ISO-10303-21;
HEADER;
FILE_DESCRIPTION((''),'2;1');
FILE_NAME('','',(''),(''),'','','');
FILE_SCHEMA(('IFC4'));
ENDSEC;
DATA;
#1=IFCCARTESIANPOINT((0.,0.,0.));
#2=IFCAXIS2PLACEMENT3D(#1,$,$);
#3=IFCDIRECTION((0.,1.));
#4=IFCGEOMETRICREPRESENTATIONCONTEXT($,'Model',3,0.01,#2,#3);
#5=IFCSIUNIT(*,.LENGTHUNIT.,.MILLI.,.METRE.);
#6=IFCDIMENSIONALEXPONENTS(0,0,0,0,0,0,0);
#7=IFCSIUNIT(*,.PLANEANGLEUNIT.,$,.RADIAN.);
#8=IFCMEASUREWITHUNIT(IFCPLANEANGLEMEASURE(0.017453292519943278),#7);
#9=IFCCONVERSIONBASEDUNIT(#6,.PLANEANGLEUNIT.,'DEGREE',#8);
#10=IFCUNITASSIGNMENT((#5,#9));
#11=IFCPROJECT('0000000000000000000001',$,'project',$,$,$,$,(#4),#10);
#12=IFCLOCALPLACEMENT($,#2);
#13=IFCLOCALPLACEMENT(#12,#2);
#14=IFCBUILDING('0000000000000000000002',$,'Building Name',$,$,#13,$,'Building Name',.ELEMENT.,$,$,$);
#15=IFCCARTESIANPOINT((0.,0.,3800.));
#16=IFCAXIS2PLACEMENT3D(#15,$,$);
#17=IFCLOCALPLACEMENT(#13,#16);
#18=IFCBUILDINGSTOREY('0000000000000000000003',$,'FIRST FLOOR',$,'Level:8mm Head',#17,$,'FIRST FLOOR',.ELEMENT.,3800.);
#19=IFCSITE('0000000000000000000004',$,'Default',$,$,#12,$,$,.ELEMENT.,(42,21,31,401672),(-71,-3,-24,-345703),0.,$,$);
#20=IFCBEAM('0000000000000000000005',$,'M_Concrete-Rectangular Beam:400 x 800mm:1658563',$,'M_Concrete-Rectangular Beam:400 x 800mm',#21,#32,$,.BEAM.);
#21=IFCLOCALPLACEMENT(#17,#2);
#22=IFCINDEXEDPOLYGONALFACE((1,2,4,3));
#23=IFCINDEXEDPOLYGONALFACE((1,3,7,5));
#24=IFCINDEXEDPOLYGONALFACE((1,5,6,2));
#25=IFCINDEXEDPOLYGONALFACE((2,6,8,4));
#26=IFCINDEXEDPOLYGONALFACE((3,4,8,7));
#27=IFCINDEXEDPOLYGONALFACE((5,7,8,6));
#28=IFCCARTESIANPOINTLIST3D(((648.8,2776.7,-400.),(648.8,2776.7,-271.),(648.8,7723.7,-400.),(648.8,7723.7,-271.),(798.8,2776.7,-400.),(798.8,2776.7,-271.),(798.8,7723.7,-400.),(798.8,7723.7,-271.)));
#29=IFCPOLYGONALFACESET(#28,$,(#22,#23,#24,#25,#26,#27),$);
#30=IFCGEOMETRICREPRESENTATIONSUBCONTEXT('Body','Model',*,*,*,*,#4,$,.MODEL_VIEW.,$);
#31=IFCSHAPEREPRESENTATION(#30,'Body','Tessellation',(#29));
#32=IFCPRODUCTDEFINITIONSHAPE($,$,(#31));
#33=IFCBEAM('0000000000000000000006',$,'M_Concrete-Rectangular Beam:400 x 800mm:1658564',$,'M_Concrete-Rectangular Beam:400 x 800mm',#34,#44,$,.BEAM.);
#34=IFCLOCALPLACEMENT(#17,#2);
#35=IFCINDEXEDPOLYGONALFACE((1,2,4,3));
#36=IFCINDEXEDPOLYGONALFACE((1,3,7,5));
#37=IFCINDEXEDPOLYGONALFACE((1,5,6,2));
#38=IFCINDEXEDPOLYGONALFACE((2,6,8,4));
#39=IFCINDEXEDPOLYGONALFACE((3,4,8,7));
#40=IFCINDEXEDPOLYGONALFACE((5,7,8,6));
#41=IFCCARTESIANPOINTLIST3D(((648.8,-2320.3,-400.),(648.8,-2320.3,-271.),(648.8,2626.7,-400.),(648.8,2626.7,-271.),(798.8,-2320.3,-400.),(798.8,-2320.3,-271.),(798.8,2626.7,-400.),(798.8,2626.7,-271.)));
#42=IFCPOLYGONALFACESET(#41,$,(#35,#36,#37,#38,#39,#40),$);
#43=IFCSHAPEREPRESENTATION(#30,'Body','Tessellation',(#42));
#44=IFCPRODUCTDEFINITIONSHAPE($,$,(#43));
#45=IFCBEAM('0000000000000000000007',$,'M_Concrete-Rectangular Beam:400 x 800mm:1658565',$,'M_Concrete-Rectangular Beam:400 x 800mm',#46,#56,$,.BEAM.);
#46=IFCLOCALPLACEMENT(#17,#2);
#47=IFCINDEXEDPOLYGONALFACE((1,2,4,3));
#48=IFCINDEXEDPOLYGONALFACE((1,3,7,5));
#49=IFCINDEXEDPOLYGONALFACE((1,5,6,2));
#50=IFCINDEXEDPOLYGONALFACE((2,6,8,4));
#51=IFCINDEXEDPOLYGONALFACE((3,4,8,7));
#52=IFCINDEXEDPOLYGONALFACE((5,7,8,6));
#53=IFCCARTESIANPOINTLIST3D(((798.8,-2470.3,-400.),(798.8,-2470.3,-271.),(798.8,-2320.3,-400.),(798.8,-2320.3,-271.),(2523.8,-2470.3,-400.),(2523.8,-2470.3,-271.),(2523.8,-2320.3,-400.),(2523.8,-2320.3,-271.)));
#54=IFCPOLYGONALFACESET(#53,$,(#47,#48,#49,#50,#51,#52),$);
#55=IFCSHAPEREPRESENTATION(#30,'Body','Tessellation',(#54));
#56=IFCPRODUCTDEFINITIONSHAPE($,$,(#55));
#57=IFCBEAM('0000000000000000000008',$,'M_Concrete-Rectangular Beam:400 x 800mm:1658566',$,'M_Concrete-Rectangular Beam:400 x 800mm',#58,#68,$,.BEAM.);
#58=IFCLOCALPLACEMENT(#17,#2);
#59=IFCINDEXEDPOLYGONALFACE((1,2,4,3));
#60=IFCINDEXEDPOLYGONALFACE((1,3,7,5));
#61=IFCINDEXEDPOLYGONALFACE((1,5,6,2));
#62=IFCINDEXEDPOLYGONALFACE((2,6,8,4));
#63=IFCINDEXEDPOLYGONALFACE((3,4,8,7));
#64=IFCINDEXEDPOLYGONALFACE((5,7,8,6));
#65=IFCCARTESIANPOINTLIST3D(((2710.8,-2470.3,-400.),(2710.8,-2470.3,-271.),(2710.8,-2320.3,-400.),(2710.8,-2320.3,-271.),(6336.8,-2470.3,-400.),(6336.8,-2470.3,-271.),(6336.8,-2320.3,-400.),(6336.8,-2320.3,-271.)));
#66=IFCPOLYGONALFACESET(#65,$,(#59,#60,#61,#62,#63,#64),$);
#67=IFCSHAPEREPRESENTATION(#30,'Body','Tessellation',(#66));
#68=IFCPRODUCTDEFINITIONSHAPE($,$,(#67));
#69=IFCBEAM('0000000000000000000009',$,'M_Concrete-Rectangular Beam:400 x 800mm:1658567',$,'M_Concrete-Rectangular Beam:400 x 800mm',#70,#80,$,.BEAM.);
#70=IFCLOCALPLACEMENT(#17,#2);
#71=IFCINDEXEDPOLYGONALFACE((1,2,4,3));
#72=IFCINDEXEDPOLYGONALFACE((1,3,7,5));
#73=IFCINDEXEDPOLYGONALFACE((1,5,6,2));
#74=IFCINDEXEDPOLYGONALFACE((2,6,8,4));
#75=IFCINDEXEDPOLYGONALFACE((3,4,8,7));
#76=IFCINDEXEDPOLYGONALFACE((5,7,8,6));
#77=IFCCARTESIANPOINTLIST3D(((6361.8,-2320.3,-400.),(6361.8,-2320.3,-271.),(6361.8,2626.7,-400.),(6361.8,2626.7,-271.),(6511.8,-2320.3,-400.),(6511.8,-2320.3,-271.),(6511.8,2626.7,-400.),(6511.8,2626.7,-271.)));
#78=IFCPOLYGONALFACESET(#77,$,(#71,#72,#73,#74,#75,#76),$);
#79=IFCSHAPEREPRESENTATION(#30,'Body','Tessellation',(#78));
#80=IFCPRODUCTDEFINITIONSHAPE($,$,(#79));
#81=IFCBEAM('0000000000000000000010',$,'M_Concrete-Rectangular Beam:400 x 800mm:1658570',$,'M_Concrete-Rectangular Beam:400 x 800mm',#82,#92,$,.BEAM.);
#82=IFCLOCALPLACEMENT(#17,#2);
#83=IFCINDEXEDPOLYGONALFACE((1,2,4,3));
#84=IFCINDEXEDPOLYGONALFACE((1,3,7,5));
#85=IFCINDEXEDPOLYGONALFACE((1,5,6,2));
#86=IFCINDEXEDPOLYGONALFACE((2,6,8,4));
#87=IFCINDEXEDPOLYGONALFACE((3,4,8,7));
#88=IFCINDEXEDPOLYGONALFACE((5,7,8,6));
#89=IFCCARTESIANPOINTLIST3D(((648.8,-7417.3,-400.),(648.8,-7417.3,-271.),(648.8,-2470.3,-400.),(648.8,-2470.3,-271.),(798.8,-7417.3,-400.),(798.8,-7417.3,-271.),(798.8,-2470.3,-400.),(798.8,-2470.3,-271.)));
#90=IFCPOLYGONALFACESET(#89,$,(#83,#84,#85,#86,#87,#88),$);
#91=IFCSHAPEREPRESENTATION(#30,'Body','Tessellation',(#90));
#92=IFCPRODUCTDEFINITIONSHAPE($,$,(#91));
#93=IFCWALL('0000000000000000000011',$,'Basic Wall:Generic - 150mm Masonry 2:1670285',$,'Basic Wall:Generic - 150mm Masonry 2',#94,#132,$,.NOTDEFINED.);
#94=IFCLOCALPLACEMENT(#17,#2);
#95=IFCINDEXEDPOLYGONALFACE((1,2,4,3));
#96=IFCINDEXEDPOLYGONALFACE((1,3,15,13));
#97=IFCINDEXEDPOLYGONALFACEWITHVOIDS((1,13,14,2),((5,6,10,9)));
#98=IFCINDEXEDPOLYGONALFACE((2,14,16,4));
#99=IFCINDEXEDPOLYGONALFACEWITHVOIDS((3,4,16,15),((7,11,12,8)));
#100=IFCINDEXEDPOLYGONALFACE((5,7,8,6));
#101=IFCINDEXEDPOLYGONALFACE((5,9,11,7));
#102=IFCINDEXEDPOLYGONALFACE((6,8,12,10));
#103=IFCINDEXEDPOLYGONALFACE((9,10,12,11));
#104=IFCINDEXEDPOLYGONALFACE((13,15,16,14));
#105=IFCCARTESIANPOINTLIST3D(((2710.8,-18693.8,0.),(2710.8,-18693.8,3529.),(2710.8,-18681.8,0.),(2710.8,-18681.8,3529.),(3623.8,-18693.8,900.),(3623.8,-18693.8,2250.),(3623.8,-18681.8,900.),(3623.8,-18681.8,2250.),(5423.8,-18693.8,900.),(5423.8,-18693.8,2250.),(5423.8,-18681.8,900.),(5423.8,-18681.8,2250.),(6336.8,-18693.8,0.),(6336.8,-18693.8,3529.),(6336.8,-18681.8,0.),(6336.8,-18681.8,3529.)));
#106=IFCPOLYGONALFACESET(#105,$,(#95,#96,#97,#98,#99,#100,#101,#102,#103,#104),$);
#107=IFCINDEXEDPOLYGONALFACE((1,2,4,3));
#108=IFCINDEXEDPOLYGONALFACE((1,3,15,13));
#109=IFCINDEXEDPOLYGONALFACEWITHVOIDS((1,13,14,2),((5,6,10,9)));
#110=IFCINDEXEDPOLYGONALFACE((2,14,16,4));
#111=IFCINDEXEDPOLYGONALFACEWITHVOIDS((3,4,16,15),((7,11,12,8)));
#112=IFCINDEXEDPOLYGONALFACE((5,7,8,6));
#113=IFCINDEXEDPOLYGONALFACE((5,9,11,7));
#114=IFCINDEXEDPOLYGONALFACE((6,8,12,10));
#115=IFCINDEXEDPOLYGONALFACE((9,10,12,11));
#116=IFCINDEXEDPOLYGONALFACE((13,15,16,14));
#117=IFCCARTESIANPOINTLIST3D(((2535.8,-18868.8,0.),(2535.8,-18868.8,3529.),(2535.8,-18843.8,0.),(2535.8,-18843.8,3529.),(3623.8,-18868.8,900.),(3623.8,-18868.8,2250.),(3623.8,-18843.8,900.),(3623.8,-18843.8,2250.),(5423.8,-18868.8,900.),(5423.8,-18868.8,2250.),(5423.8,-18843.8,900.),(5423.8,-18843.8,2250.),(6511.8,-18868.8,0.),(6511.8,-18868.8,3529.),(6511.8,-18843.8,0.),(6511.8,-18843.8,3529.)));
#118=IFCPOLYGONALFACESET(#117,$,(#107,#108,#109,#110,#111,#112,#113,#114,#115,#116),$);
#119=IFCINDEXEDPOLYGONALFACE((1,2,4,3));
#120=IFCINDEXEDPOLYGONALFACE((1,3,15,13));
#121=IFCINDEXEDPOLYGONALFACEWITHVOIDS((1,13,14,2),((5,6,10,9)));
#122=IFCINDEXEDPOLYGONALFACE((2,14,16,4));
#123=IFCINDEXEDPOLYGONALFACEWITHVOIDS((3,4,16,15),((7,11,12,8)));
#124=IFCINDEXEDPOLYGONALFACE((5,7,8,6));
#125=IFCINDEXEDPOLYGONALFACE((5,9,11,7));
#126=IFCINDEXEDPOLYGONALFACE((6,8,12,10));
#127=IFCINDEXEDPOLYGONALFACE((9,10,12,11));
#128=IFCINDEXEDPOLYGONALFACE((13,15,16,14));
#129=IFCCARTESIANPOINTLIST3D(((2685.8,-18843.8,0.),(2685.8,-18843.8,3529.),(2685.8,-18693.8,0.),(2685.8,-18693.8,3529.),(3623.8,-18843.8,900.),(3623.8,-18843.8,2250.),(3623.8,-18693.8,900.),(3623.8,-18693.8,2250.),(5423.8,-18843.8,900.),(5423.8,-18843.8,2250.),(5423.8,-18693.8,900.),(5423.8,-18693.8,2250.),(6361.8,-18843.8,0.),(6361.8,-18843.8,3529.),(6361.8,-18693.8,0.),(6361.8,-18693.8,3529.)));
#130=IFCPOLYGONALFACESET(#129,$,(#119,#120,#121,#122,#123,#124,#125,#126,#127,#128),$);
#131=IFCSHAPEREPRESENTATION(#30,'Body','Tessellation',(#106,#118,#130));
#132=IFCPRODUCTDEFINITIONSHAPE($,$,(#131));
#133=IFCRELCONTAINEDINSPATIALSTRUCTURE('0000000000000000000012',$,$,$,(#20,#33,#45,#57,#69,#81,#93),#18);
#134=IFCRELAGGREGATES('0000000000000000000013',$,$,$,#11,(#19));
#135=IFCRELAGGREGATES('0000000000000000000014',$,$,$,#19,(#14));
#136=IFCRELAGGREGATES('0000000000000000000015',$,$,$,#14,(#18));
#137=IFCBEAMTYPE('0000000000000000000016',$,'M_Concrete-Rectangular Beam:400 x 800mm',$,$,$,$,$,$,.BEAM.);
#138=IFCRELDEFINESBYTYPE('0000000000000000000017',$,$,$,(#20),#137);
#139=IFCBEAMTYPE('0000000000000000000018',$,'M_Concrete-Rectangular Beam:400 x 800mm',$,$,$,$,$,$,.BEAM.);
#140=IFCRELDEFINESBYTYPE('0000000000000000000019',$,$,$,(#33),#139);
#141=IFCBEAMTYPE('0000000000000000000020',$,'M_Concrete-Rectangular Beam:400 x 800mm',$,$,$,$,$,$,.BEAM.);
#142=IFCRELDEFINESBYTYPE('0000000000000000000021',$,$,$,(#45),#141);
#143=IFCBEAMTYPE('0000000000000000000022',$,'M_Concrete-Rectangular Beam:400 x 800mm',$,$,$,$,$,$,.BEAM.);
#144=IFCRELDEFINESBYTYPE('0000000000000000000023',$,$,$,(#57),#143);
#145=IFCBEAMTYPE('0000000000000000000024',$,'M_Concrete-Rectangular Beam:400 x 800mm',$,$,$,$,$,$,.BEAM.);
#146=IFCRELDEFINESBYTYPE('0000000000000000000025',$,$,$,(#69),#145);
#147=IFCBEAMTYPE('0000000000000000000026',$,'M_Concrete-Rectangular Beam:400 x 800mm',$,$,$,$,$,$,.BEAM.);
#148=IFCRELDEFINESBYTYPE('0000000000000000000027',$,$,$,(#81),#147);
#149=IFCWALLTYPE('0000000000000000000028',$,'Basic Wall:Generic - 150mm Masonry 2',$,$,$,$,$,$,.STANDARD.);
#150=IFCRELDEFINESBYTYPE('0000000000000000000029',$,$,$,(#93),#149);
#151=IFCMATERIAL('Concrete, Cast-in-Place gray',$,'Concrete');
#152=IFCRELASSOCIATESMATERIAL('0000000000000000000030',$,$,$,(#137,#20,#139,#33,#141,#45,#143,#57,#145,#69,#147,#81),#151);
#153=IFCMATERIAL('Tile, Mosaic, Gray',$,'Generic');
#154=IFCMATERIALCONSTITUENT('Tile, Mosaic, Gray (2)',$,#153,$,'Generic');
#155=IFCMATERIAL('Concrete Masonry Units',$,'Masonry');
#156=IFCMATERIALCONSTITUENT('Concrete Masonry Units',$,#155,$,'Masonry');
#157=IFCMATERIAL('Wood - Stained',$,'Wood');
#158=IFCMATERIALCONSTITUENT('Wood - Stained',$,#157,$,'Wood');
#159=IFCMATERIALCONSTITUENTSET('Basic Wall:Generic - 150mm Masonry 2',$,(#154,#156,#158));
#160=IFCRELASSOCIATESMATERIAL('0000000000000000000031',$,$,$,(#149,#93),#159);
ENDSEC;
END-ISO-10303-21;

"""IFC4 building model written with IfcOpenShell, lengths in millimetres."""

from ifc_helpers import new_model, entity, si_unit, converted_unit, direction, frame, origin, place, context, subcontext, project, spatial, indexed_curve, outline, extrude, source, transform, mapped, material, constituent, constituent_set, type_object, type_shapes, element, save


model = new_model("IFC4")

# Units and contexts
model_context = context("Model", 3, precision=0.01, world=origin(), true_north=direction((0.0, 1.0)))
body_context = subcontext(model_context, "Body", "Model", "MODEL_VIEW")
ifc_project = project(units=[si_unit("LENGTHUNIT", "METRE", prefix="MILLI"), converted_unit("PLANEANGLEUNIT", "DEGREE", entity("IfcPlaneAngleMeasure", 0.017453292519943278), si_unit("PLANEANGLEUNIT", "RADIAN"), dimensions=[0, 0, 0, 0, 0, 0, 0])], contexts=[model_context])

# Site, building, storey
site_placement = place(None, origin())
site = spatial("IfcSite", under=ifc_project, at=site_placement, Name="Default", CompositionType="ELEMENT", RefLatitude=(42, 21, 31, 401672), RefLongitude=(-71, -3, -24, -345703), RefElevation=0.0)
building_placement = place(site_placement, origin())
building = spatial("IfcBuilding", under=site, at=building_placement, Name="Building Name", LongName="Building Name", CompositionType="ELEMENT")
storey_placement = place(building_placement, frame((0.0, 0.0, 3800.0)))
storey = spatial("IfcBuildingStorey", under=building, at=storey_placement, Name="FIRST FLOOR", ObjectType="Level:8mm Head", LongName="FIRST FLOOR", CompositionType="ELEMENT", Elevation=3800.0)

# Beams
ifc_material_1 = material(Name="Concrete, Cast-in-Place gray", Category="Concrete")
beam_type_1 = type_object("IfcBeamType", Name="M_Concrete-Rectangular Beam:400 x 800mm", PredefinedType="BEAM", material=ifc_material_1)
shared_shape_1 = source(origin(), body_context, "Body", "SweptSolid", [
    extrude(outline(indexed_curve([(-75.0, -64.5), (75.0, -64.5), (75.0, 64.5), (-75.0, 64.5), (-75.0, -64.5)], self_intersect=False)), frame((723.8, 2776.7, 3464.5), z_axis=(0.0, 1.0, 0.0), x_axis=(-1.0, 0.0, 0.0)), (0.0, 0.0, 1.0), 4947.0),
])
type_shapes(beam_type_1, [shared_shape_1])
beam_1_placement = place(storey_placement, frame((0.0, 0.0, -3800.0)))
element("IfcBeam", 1, at=beam_1_placement, inside=storey, type_object=beam_type_1, material=ifc_material_1, Name="M_Concrete-Rectangular Beam:400 x 800mm:1658563", ObjectType="M_Concrete-Rectangular Beam:400 x 800mm", PredefinedType="BEAM", context=body_context, shape_type="MappedRepresentation", body=[
    mapped(shared_shape_1, transform((0.0, 0.0, 0.0), scale=1.0)),
])
beam_type_2 = type_object("IfcBeamType", Name="M_Concrete-Rectangular Beam:400 x 800mm", PredefinedType="BEAM", material=ifc_material_1)
shared_shape_2 = source(origin(), body_context, "Body", "SweptSolid", [
    extrude(outline(indexed_curve([(-75.0, -64.5), (75.0, -64.5), (75.0, 64.5), (-75.0, 64.5), (-75.0, -64.5)], self_intersect=False)), frame((723.8, 2626.7, 3464.5), z_axis=(0.0, -1.0, 0.0), x_axis=(-1.0, 0.0, 0.0)), (0.0, 0.0, 1.0), 4947.0),
])
type_shapes(beam_type_2, [shared_shape_2])
beam_2_placement = place(storey_placement, frame((0.0, 0.0, -3800.0)))
element("IfcBeam", 2, at=beam_2_placement, inside=storey, type_object=beam_type_2, material=ifc_material_1, Name="M_Concrete-Rectangular Beam:400 x 800mm:1658564", ObjectType="M_Concrete-Rectangular Beam:400 x 800mm", PredefinedType="BEAM", context=body_context, shape_type="MappedRepresentation", body=[
    mapped(shared_shape_2, transform((0.0, 0.0, 0.0), scale=1.0)),
])
beam_type_3 = type_object("IfcBeamType", Name="M_Concrete-Rectangular Beam:400 x 800mm", PredefinedType="BEAM", material=ifc_material_1)
shared_shape_3 = source(origin(), body_context, "Body", "SweptSolid", [
    extrude(outline(indexed_curve([(-64.5, -75.0), (64.5, -75.0), (64.5, 75.0), (-64.5, 75.0), (-64.5, -75.0)], self_intersect=False)), frame((798.8, -2395.3, 3464.5), z_axis=(1.0, 0.0, 0.0), x_axis=(0.0, 0.0, -1.0)), (0.0, 0.0, 1.0), 1725.0),
])
type_shapes(beam_type_3, [shared_shape_3])
beam_3_placement = place(storey_placement, frame((0.0, 0.0, -3800.0)))
element("IfcBeam", 3, at=beam_3_placement, inside=storey, type_object=beam_type_3, material=ifc_material_1, Name="M_Concrete-Rectangular Beam:400 x 800mm:1658565", ObjectType="M_Concrete-Rectangular Beam:400 x 800mm", PredefinedType="BEAM", context=body_context, shape_type="MappedRepresentation", body=[
    mapped(shared_shape_3, transform((0.0, 0.0, 0.0), scale=1.0)),
])
beam_type_4 = type_object("IfcBeamType", Name="M_Concrete-Rectangular Beam:400 x 800mm", PredefinedType="BEAM", material=ifc_material_1)
shared_shape_4 = source(origin(), body_context, "Body", "SweptSolid", [
    extrude(outline(indexed_curve([(-64.5, -75.0), (64.5, -75.0), (64.5, 75.0), (-64.5, 75.0), (-64.5, -75.0)], self_intersect=False)), frame((2710.8, -2395.3, 3464.5), z_axis=(1.0, 0.0, 0.0), x_axis=(0.0, 0.0, -1.0)), (0.0, 0.0, 1.0), 3626.0),
])
type_shapes(beam_type_4, [shared_shape_4])
beam_4_placement = place(storey_placement, frame((0.0, 0.0, -3800.0)))
element("IfcBeam", 4, at=beam_4_placement, inside=storey, type_object=beam_type_4, material=ifc_material_1, Name="M_Concrete-Rectangular Beam:400 x 800mm:1658566", ObjectType="M_Concrete-Rectangular Beam:400 x 800mm", PredefinedType="BEAM", context=body_context, shape_type="MappedRepresentation", body=[
    mapped(shared_shape_4, transform((0.0, 0.0, 0.0), scale=1.0)),
])
beam_type_5 = type_object("IfcBeamType", Name="M_Concrete-Rectangular Beam:400 x 800mm", PredefinedType="BEAM", material=ifc_material_1)
shared_shape_5 = source(origin(), body_context, "Body", "SweptSolid", [
    extrude(outline(indexed_curve([(-75.0, -64.5), (75.0, -64.5), (75.0, 64.5), (-75.0, 64.5), (-75.0, -64.5)], self_intersect=False)), frame((6436.8, -2320.3, 3464.5), z_axis=(0.0, 1.0, 0.0), x_axis=(-1.0, 0.0, 0.0)), (0.0, 0.0, 1.0), 4947.0),
])
type_shapes(beam_type_5, [shared_shape_5])
beam_5_placement = place(storey_placement, frame((0.0, 0.0, -3800.0)))
element("IfcBeam", 5, at=beam_5_placement, inside=storey, type_object=beam_type_5, material=ifc_material_1, Name="M_Concrete-Rectangular Beam:400 x 800mm:1658567", ObjectType="M_Concrete-Rectangular Beam:400 x 800mm", PredefinedType="BEAM", context=body_context, shape_type="MappedRepresentation", body=[
    mapped(shared_shape_5, transform((0.0, 0.0, 0.0), scale=1.0)),
])
beam_type_6 = type_object("IfcBeamType", Name="M_Concrete-Rectangular Beam:400 x 800mm", PredefinedType="BEAM", material=ifc_material_1)
shared_shape_6 = source(origin(), body_context, "Body", "SweptSolid", [
    extrude(outline(indexed_curve([(-75.0, -64.5), (75.0, -64.5), (75.0, 64.5), (-75.0, 64.5), (-75.0, -64.5)], self_intersect=False)), frame((723.8, -2470.3, 3464.5), z_axis=(0.0, -1.0, 0.0), x_axis=(-1.0, 0.0, 0.0)), (0.0, 0.0, 1.0), 4947.0),
])
type_shapes(beam_type_6, [shared_shape_6])
beam_6_placement = place(storey_placement, frame((0.0, 0.0, -3800.0)))
element("IfcBeam", 6, at=beam_6_placement, inside=storey, type_object=beam_type_6, material=ifc_material_1, Name="M_Concrete-Rectangular Beam:400 x 800mm:1658570", ObjectType="M_Concrete-Rectangular Beam:400 x 800mm", PredefinedType="BEAM", context=body_context, shape_type="MappedRepresentation", body=[
    mapped(shared_shape_6, transform((0.0, 0.0, 0.0), scale=1.0)),
])

# Shared definitions
ifc_material_2 = material(Name="Tile, Mosaic, Gray", Category="Generic")
ifc_constituent_1 = constituent(ifc_material_2, Name="Tile, Mosaic, Gray (2)", Category="Generic")
ifc_material_3 = material(Name="Concrete Masonry Units", Category="Masonry")
ifc_constituent_2 = constituent(ifc_material_3, Name="Concrete Masonry Units", Category="Masonry")
ifc_material_4 = material(Name="Wood - Stained", Category="Wood")
ifc_constituent_3 = constituent(ifc_material_4, Name="Wood - Stained", Category="Wood")
ifc_constituent_set_1 = constituent_set(constituents=[ifc_constituent_1, ifc_constituent_2, ifc_constituent_3], Name="Basic Wall:Generic - 150mm Masonry 2")
wall_type_1 = type_object("IfcWallType", Name="Basic Wall:Generic - 150mm Masonry 2", PredefinedType="STANDARD", material=ifc_constituent_set_1)

# Wall, opening
wall_1_placement = place(storey_placement, frame((2710.8, -18775.3, 0.0)))
wall_1 = element("IfcWall", 7, at=wall_1_placement, inside=storey, type_object=wall_type_1, material=ifc_constituent_set_1, Name="Basic Wall:Generic - 150mm Masonry 2:1670285", ObjectType="Basic Wall:Generic - 150mm Masonry 2", PredefinedType="NOTDEFINED", context=body_context, shape_type="SweptSolid", body=[
    extrude(outline(indexed_curve([(-1764.5, -1813.0), (1764.5, -1813.0), (1764.5, 1813.0), (-1764.5, 1813.0), (-1764.5, -1813.0)], self_intersect=False), holes=[indexed_curve([(485.5, 900.0), (485.5, -900.0), (-864.5, -900.0), (-864.5, 900.0), (485.5, 900.0)], self_intersect=False)]), frame((1813.0, 81.5, 1764.5), z_axis=(0.0, 1.0, 0.0), x_axis=(0.0, 0.0, 1.0)), (0.0, 0.0, 1.0), 12.0),
    extrude(outline(indexed_curve([(-1764.5, -1988.0), (1764.5, -1988.0), (1764.5, 1988.0), (-1764.5, 1988.0), (-1764.5, -1988.0)], self_intersect=False), holes=[indexed_curve([(485.5, 900.0), (485.5, -900.0), (-864.5, -900.0), (-864.5, 900.0), (485.5, 900.0)], self_intersect=False)]), frame((1813.0, -93.5, 1764.5), z_axis=(0.0, 1.0, 0.0), x_axis=(0.0, 0.0, 1.0)), (0.0, 0.0, 1.0), 25.0),
    extrude(outline(indexed_curve([(-1764.5, -1838.0), (1764.5, -1838.0), (1764.5, 1838.0), (-1764.5, 1838.0), (-1764.5, -1838.0)], self_intersect=False), holes=[indexed_curve([(485.5, 900.0), (485.5, -900.0), (-864.5, -900.0), (-864.5, 900.0), (485.5, 900.0)], self_intersect=False)]), frame((1813.0, -68.5, 1764.5), z_axis=(0.0, 1.0, 0.0), x_axis=(0.0, 0.0, 1.0)), (0.0, 0.0, 1.0), 150.0),
])
opening_1_placement = place(wall_1_placement, frame((2713.0, 93.5, 900.0)))
element("IfcOpeningElement", 8, at=opening_1_placement, cuts=wall_1, PredefinedType="OPENING", context=body_context, shape_type="SweptSolid", body=[
    extrude(outline(indexed_curve([(1350.0, 0.0), (1350.0, 1800.0), (0.0, 1800.0), (0.0, 0.0), (1350.0, 0.0)], self_intersect=False)), frame((0.0, 0.0, 0.0), z_axis=(0.0, -1.0, 0.0), x_axis=(0.0, 0.0, 1.0)), (0.0, 0.0, 1.0), 187.0),
])

save(model, "model.ifc")
